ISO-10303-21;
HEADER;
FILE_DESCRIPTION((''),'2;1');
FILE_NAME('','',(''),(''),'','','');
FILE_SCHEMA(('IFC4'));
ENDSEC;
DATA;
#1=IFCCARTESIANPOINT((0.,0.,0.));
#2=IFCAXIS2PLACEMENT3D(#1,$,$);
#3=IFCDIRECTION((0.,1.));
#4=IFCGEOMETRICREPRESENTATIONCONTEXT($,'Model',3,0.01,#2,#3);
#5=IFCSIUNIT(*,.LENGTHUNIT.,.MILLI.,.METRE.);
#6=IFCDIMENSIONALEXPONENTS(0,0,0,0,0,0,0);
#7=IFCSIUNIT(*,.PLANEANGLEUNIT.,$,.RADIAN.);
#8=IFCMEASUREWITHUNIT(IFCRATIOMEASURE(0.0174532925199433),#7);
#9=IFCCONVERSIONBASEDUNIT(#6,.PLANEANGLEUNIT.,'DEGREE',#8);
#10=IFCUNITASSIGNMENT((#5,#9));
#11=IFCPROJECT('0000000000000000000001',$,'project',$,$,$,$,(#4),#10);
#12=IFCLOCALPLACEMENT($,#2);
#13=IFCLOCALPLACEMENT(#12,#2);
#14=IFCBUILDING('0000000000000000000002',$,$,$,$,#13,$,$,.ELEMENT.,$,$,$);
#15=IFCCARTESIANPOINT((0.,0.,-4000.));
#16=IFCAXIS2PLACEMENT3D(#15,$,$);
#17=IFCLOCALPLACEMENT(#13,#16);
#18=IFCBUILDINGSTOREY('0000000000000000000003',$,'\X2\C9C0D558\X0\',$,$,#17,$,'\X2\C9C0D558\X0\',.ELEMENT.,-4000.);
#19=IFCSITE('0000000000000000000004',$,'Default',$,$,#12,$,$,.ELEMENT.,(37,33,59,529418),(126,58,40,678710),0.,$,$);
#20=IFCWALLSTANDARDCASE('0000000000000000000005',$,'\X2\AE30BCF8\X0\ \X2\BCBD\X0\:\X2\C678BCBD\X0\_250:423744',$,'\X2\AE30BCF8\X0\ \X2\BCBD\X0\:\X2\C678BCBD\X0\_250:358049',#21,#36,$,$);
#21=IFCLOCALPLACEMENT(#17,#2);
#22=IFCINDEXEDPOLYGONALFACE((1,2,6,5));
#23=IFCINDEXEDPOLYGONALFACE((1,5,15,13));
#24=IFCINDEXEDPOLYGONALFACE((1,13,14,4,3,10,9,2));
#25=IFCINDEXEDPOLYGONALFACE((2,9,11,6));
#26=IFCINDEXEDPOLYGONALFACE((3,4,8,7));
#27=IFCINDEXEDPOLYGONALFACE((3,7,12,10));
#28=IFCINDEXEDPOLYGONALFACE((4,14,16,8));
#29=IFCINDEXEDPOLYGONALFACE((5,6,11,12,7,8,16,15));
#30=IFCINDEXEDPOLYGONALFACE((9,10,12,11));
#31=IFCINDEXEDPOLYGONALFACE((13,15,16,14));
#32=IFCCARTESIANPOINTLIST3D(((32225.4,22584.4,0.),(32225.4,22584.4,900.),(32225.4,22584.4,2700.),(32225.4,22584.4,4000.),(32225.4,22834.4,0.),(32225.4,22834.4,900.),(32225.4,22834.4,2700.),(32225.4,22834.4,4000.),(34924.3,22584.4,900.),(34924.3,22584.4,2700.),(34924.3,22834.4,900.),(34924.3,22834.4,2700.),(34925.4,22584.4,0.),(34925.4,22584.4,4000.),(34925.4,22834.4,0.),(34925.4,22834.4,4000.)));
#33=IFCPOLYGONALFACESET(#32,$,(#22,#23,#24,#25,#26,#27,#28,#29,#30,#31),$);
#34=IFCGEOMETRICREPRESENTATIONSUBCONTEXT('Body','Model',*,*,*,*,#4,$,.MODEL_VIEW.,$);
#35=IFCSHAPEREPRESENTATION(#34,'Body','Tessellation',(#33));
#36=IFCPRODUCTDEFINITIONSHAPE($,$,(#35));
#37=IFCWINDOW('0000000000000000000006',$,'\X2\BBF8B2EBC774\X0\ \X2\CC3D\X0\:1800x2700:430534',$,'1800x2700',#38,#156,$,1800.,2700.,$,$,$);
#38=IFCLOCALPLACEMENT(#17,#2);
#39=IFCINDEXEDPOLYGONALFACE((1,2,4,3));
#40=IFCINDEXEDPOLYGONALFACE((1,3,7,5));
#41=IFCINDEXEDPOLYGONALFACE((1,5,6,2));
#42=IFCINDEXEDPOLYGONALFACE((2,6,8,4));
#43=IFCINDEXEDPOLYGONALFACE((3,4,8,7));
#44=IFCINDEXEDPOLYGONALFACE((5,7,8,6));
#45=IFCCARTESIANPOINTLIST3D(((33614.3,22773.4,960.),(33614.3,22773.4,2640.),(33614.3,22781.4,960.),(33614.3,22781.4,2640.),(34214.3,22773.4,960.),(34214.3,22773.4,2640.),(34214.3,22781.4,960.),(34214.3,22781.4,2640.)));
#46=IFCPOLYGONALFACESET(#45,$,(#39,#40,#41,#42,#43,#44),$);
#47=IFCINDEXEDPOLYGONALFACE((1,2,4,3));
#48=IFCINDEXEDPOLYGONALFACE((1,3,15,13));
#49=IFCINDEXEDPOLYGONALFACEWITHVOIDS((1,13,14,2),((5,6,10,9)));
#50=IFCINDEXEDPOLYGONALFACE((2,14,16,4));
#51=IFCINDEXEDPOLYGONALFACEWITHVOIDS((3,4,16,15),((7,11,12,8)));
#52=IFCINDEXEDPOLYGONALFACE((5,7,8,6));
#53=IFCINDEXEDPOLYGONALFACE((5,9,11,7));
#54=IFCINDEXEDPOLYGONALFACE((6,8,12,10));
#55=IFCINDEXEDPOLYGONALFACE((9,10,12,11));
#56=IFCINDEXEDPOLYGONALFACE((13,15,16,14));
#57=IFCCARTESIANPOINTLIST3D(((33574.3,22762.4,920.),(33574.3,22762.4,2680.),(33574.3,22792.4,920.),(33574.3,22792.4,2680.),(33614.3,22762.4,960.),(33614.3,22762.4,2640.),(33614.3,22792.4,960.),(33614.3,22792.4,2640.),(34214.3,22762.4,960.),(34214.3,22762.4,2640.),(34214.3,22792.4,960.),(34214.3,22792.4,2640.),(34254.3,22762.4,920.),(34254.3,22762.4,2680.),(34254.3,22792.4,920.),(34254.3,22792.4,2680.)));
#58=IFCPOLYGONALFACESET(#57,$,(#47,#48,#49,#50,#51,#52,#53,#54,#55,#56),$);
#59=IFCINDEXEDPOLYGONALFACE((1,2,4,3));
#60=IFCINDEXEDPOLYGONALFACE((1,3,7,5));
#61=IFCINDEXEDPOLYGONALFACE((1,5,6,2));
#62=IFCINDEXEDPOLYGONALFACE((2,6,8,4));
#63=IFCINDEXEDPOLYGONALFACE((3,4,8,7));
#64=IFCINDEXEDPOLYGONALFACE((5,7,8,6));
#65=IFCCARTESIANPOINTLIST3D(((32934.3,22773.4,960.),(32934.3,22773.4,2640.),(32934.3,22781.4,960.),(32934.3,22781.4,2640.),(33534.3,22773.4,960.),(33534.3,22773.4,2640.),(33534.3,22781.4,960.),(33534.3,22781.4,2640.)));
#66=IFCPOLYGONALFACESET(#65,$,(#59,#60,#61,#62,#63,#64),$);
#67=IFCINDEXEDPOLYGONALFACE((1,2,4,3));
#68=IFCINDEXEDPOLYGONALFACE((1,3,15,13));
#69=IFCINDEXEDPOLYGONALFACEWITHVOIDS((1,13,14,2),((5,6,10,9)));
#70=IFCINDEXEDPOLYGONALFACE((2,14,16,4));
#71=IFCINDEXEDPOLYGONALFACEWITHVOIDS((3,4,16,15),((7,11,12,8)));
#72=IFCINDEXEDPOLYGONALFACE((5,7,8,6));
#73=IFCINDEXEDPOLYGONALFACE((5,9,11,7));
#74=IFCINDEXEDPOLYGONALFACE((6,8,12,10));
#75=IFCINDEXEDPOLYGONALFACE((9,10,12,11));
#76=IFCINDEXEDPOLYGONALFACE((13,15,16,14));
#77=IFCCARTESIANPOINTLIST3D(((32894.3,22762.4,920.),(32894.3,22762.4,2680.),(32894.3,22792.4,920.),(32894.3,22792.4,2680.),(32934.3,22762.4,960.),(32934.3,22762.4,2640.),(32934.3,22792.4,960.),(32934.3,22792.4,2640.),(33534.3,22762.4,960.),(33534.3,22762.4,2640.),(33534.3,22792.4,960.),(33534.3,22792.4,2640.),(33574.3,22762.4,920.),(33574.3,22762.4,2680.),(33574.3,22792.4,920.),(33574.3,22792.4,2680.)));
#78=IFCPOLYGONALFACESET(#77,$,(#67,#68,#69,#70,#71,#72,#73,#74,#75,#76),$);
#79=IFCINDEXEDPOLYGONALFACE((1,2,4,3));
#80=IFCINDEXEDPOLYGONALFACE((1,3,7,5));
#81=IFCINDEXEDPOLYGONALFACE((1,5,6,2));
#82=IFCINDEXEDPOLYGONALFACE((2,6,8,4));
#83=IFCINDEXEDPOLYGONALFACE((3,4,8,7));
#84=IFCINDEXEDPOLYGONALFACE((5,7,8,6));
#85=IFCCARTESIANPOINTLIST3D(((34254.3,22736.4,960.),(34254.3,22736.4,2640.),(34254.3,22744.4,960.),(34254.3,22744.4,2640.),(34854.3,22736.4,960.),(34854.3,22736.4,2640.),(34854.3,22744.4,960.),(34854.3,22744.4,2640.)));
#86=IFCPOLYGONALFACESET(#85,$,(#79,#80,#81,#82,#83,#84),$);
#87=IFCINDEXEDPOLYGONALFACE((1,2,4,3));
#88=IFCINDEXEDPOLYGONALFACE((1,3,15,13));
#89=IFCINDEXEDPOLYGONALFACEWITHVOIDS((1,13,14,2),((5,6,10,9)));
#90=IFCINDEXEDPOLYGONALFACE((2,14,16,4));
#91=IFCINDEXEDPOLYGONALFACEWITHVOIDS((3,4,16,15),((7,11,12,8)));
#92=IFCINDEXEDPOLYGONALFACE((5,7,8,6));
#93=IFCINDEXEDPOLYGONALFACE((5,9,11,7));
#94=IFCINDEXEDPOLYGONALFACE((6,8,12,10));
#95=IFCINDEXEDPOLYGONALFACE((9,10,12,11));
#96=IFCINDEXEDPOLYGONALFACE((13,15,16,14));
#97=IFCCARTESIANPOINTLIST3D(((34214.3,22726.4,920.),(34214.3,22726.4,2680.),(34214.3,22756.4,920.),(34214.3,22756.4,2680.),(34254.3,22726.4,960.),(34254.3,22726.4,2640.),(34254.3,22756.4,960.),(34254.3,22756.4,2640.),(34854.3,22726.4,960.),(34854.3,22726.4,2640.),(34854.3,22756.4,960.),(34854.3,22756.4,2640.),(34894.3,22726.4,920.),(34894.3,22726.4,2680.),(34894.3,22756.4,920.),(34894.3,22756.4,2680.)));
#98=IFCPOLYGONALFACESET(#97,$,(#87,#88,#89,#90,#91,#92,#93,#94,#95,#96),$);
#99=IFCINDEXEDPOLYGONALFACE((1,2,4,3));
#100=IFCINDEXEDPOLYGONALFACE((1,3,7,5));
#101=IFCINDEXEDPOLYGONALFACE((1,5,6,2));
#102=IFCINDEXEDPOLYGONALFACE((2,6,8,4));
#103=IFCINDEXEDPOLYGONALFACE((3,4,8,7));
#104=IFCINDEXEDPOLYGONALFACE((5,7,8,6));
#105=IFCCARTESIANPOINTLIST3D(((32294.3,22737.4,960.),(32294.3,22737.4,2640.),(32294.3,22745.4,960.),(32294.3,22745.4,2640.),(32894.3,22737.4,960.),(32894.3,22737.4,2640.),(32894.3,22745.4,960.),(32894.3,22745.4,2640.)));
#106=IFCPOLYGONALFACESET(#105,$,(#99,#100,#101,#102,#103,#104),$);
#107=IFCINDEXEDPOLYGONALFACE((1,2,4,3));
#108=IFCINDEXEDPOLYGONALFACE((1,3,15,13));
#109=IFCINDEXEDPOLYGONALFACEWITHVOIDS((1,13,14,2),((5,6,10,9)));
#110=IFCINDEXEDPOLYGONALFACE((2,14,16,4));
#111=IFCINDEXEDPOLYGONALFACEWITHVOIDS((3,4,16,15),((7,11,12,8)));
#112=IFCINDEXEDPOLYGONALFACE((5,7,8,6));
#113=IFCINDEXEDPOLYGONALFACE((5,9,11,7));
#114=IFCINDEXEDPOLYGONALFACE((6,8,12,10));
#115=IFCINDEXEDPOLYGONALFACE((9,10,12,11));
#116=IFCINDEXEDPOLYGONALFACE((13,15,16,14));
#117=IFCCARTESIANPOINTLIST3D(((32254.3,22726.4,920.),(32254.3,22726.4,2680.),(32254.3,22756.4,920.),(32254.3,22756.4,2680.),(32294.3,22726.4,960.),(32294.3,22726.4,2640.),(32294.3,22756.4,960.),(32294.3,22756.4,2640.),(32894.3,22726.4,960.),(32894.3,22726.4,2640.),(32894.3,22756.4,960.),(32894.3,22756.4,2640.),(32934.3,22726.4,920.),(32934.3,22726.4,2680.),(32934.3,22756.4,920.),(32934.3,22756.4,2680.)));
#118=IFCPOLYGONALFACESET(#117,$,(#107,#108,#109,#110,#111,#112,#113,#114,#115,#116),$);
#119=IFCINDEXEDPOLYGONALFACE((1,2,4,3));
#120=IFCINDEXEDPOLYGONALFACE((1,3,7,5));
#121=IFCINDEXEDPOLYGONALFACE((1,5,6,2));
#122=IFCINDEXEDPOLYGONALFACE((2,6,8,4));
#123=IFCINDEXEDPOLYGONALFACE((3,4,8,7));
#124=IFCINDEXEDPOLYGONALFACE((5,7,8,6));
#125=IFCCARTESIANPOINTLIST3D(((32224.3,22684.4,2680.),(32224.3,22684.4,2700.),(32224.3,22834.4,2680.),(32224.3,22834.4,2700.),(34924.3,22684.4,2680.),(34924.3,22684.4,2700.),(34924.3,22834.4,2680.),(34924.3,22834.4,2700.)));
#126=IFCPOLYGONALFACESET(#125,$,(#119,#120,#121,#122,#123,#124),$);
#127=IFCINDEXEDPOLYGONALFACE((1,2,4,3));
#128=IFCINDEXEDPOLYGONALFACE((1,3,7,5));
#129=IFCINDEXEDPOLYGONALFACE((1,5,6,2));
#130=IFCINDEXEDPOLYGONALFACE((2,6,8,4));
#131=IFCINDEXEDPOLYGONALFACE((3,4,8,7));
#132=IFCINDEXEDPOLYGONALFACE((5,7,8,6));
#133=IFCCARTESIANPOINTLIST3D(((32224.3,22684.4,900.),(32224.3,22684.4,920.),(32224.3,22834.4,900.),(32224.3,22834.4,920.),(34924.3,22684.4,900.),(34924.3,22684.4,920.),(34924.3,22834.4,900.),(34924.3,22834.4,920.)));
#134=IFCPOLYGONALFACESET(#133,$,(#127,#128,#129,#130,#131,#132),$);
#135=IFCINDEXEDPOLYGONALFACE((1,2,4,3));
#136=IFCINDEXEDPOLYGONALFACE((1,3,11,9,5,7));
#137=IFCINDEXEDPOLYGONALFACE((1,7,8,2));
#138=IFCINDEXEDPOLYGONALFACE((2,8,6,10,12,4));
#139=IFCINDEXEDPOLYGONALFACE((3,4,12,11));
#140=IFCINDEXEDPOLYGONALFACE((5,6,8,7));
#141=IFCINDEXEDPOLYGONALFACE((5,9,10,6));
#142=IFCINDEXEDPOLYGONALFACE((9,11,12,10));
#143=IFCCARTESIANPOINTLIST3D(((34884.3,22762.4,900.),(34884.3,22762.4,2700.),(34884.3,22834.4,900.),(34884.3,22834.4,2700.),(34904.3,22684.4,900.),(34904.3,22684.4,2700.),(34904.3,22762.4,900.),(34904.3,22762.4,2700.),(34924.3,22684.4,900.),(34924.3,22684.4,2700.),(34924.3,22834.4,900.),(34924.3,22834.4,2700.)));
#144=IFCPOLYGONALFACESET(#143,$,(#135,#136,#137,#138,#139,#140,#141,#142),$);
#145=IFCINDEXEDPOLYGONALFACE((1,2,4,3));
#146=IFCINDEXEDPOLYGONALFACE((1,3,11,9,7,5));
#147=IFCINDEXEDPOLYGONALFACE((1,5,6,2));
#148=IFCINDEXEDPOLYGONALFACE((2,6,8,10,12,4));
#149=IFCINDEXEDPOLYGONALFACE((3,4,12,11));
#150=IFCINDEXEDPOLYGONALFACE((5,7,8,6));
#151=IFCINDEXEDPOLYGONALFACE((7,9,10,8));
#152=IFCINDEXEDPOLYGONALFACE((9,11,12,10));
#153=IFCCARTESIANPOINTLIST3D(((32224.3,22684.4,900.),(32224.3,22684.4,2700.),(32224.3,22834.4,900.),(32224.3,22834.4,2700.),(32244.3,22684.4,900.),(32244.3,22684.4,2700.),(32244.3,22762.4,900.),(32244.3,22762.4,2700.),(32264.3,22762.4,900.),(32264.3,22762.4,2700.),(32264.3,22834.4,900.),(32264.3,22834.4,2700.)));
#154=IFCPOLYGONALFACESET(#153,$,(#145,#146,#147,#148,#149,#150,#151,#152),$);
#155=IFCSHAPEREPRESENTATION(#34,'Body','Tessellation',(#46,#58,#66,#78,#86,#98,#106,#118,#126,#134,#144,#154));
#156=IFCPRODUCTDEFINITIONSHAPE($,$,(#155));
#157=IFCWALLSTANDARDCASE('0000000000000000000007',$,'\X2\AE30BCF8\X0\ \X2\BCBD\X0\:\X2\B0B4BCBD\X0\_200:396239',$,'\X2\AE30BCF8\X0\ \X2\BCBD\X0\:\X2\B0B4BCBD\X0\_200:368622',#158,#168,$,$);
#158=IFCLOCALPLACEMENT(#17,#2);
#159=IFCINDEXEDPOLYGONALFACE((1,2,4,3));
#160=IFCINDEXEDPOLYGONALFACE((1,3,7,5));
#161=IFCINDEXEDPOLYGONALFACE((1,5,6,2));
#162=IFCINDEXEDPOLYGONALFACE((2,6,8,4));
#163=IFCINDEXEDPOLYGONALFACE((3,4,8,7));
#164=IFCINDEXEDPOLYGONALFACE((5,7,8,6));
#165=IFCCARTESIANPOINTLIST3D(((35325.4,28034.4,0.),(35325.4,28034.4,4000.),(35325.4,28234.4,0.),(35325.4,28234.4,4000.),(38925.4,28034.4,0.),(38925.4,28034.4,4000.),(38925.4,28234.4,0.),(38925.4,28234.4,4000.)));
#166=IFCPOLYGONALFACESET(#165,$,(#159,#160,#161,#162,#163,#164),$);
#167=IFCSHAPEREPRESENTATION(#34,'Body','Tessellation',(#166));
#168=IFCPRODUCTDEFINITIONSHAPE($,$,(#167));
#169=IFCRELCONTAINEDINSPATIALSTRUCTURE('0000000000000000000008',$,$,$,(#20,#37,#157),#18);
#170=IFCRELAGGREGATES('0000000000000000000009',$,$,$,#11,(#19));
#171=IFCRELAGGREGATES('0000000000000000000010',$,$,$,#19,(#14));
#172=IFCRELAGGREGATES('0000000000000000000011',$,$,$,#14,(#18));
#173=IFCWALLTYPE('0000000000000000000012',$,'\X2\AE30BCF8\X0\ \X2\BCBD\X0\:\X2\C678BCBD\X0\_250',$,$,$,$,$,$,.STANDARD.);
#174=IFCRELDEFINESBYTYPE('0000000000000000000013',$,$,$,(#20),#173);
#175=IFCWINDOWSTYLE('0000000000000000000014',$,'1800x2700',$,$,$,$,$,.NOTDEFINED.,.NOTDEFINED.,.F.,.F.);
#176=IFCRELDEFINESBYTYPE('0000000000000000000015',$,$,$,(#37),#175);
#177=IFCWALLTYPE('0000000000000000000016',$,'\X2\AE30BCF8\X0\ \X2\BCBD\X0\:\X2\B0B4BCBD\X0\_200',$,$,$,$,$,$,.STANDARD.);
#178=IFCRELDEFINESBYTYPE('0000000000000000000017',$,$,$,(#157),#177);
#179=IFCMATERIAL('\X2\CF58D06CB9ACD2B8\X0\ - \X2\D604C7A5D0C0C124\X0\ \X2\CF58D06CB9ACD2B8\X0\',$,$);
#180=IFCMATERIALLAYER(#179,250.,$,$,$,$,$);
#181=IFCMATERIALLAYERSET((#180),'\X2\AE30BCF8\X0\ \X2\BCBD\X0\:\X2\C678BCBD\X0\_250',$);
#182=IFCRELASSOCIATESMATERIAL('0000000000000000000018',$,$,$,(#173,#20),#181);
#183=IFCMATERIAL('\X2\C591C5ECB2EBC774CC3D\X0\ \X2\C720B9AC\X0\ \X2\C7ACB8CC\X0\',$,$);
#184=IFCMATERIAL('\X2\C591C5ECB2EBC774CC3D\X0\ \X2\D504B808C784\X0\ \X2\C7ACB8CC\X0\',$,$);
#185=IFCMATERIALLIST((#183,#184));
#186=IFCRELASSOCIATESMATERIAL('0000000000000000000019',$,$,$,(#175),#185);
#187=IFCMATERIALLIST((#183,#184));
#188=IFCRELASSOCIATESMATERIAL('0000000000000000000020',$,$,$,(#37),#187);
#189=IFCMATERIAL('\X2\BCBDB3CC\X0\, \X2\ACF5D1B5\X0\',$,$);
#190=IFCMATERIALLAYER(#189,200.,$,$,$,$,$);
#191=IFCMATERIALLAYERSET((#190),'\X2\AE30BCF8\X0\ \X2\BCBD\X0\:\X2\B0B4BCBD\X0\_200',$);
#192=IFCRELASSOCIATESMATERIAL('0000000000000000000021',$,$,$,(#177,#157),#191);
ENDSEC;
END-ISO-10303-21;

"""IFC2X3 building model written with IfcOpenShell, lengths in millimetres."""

from ifc_helpers import new_model, entity, si_unit, converted_unit, direction, frame, frame_2d, origin, origin_2d_with_axis, place, context, subcontext, project, spatial, polyline, rectangle, outline, extrude, source, transform, mapped, material, material_list, layer, layer_set, layer_usage, type_object, type_shapes, element, fill, save


model = new_model("IFC2X3")

# Units and contexts
model_context = context("Model", 3, precision=0.01, world=origin(), true_north=direction((0.0, 1.0)))
body_context = subcontext(model_context, "Body", "Model", "MODEL_VIEW")
ifc_project = project(units=[si_unit("LENGTHUNIT", "METRE", prefix="MILLI"), converted_unit("PLANEANGLEUNIT", "DEGREE", entity("IfcRatioMeasure", 0.0174532925199433), si_unit("PLANEANGLEUNIT", "RADIAN"), dimensions=[0, 0, 0, 0, 0, 0, 0])], contexts=[model_context])

# Site, building, storey
site_placement = place(None, origin())
site = spatial("IfcSite", under=ifc_project, at=site_placement, Name="Default", CompositionType="ELEMENT", RefLatitude=(37, 33, 59, 529418), RefLongitude=(126, 58, 40, 678710), RefElevation=0.0)
building_placement = place(site_placement, origin())
building = spatial("IfcBuilding", under=site, at=building_placement, CompositionType="ELEMENT")
storey_placement = place(building_placement, frame((0.0, 0.0, -4000.0)))
storey = spatial("IfcBuildingStorey", under=building, at=storey_placement, Name="지하", LongName="지하", CompositionType="ELEMENT", Elevation=-4000.0)

# Shared definitions
ifc_material_1 = material(Name="콘크리트 - 현장타설 콘크리트")

# Wall, opening, window
ifc_material_2 = material(Name="양여닫이창 유리 재료")
ifc_material_3 = material(Name="양여닫이창 프레임 재료")
ifc_layer_1 = layer(ifc_material_1, 250.0)
ifc_layer_set_1 = layer_set([ifc_layer_1], Name="기본 벽:외벽_250")
ifc_layer_usage_1 = layer_usage(ifc_layer_set_1, "AXIS2", "NEGATIVE", 125.0)
wall_type_1 = type_object("IfcWallType", Name="기본 벽:외벽_250", PredefinedType="STANDARD", material=ifc_layer_set_1)
wall_1_placement = place(storey_placement, frame((32225.4, 22709.4, 0.0)))
wall_1 = element("IfcWallStandardCase", 1, at=wall_1_placement, inside=storey, type_object=wall_type_1, material=ifc_layer_usage_1, Name="기본 벽:외벽_250:423744", ObjectType="기본 벽:외벽_250:358049", context=body_context, shape_type="SweptSolid", body=[
    extrude(rectangle(XDim=2700.0, YDim=250.0, at=frame_2d((1350.0, 0.0), x_axis=(-1.0, 0.0))), origin(), (0.0, 0.0, 1.0), 4000.0),
])
opening_1_placement = place(wall_1_placement, frame((-1.1, -125.0, 900.0)))
opening_1 = element("IfcOpeningElement", 2, at=opening_1_placement, cuts=wall_1, ObjectType="Opening", context=body_context, shape_type="SweptSolid", body=[
    extrude(rectangle(XDim=1800.0, YDim=2700.0, at=frame_2d((900.0, 1350.0), x_axis=(1.0, 0.0))), frame((0.0, 0.0, 0.0), z_axis=(0.0, 1.0, 0.0), x_axis=(0.0, 0.0, 1.0)), (0.0, 0.0, 1.0), 250.0),
])
ifc_material_list_1 = material_list([ifc_material_2, ifc_material_3])
ifc_material_list_2 = material_list([ifc_material_2, ifc_material_3])
window_style_1 = type_object("IfcWindowStyle", Name="1800x2700", ConstructionType="NOTDEFINED", OperationType="NOTDEFINED", ParameterTakesPrecedence=False, Sizeable=False, material=ifc_material_list_2)
shared_shape_1 = source(origin(), body_context, "Body", "SweptSolid", [
    extrude(rectangle(XDim=8.0, YDim=600.0, at=frame_2d((0.0, 0.0), x_axis=(1.0, 0.0))), frame((1690.0, 193.0, 60.0), z_axis=(0.0, 0.0, 1.0), x_axis=(0.0, 1.0, 0.0)), (0.0, 0.0, 1.0), 1680.0),
    extrude(outline(polyline([(-880.0, -340.0), (880.0, -340.0), (880.0, 340.0), (-880.0, 340.0), (-880.0, -340.0)]), holes=[polyline([(840.0, -300.0), (-840.0, -300.0), (-840.0, 300.0), (840.0, 300.0), (840.0, -300.0)])]), frame((1690.0, 178.0, 900.0), z_axis=(0.0, 1.0, 0.0), x_axis=(0.0, 0.0, -1.0)), (0.0, 0.0, 1.0), 30.0),
    extrude(rectangle(XDim=8.0, YDim=600.0, at=origin_2d_with_axis()), frame((1010.0, 193.0, 60.0), z_axis=(0.0, 0.0, 1.0), x_axis=(0.0, 1.0, 0.0)), (0.0, 0.0, 1.0), 1680.0),
    extrude(outline(polyline([(-880.0, -340.0), (880.0, -340.0), (880.0, 340.0), (-880.0, 340.0), (-880.0, -340.0)]), holes=[polyline([(840.0, -300.0), (-840.0, -300.0), (-840.0, 300.0), (840.0, 300.0), (840.0, -300.0)])]), frame((1010.0, 178.0, 900.0), z_axis=(0.0, 1.0, 0.0), x_axis=(0.0, 0.0, -1.0)), (0.0, 0.0, 1.0), 30.0),
    extrude(rectangle(XDim=8.0, YDim=600.0, at=frame_2d((0.0, 0.0), x_axis=(1.0, 0.0))), frame((2330.0, 156.0, 60.0), z_axis=(0.0, 0.0, 1.0), x_axis=(0.0, 1.0, 0.0)), (0.0, 0.0, 1.0), 1680.0),
    extrude(outline(polyline([(-880.0, -340.0), (880.0, -340.0), (880.0, 340.0), (-880.0, 340.0), (-880.0, -340.0)]), holes=[polyline([(840.0, -300.0), (-840.0, -300.0), (-840.0, 300.0), (840.0, 300.0), (840.0, -300.0)])]), frame((2330.0, 142.0, 900.0), z_axis=(0.0, 1.0, 0.0), x_axis=(0.0, 0.0, -1.0)), (0.0, 0.0, 1.0), 30.0),
    extrude(rectangle(XDim=8.0, YDim=600.0, at=frame_2d((0.0, 0.0), x_axis=(1.0, 0.0))), frame((370.0, 157.0, 60.0), z_axis=(0.0, 0.0, 1.0), x_axis=(0.0, 1.0, 0.0)), (0.0, 0.0, 1.0), 1680.0),
    extrude(outline(polyline([(-880.0, -340.0), (880.0, -340.0), (880.0, 340.0), (-880.0, 340.0), (-880.0, -340.0)]), holes=[polyline([(840.0, -300.0), (-840.0, -300.0), (-840.0, 300.0), (840.0, 300.0), (840.0, -300.0)])]), frame((370.0, 142.0, 900.0), z_axis=(0.0, 1.0, 0.0), x_axis=(0.0, 0.0, -1.0)), (0.0, 0.0, 1.0), 30.0),
    extrude(rectangle(XDim=2700.0, YDim=150.0, at=origin_2d_with_axis()), frame((1350.0, 175.0, 1780.0), z_axis=(0.0, 0.0, 1.0), x_axis=(-1.0, 0.0, 0.0)), (0.0, 0.0, 1.0), 20.0),
    extrude(rectangle(XDim=2700.0, YDim=150.0, at=origin_2d_with_axis()), frame((1350.0, 175.0, 0.0), z_axis=(0.0, 0.0, 1.0), x_axis=(-1.0, 0.0, 0.0)), (0.0, 0.0, 1.0), 20.0),
    extrude(outline(polyline([(-74.0, -20.0), (-2.0, -20.0), (-2.0, 0.0), (76.0, 0.0), (76.0, 20.0), (-74.0, 20.0), (-74.0, -20.0)])), frame((2680.0, 176.0, 0.0), z_axis=(0.0, 0.0, 1.0), x_axis=(0.0, -1.0, 0.0)), (0.0, 0.0, 1.0), 1800.0),
    extrude(outline(polyline([(-20.0, -74.0), (20.0, -74.0), (20.0, 76.0), (0.0, 76.0), (0.0, -2.0), (-20.0, -2.0), (-20.0, -74.0)])), frame((20.0, 176.0, 0.0), z_axis=(0.0, 0.0, 1.0), x_axis=(-1.0, 0.0, 0.0)), (0.0, 0.0, 1.0), 1800.0),
])
type_shapes(window_style_1, [shared_shape_1])
window_1_placement = place(opening_1_placement, origin())
window_1 = element("IfcWindow", 3, at=window_1_placement, inside=storey, type_object=window_style_1, material=ifc_material_list_1, Name="미닫이 창:1800x2700:430534", ObjectType="1800x2700", OverallHeight=1800.0, OverallWidth=2700.0, context=body_context, shape_type="MappedRepresentation", body=[
    mapped(shared_shape_1, transform((0.0, 0.0, 0.0), scale=1.0)),
])
fill(opening_1, window_1)

# Wall
ifc_material_4 = material(Name="벽돌, 공통")
ifc_layer_2 = layer(ifc_material_4, 200.0)
ifc_layer_set_2 = layer_set([ifc_layer_2], Name="기본 벽:내벽_200")
ifc_layer_usage_2 = layer_usage(ifc_layer_set_2, "AXIS2", "NEGATIVE", 100.0)
wall_type_2 = type_object("IfcWallType", Name="기본 벽:내벽_200", PredefinedType="STANDARD", material=ifc_layer_set_2)
wall_2_placement = place(storey_placement, frame((35325.4, 28134.4, 0.0)))
element("IfcWallStandardCase", 4, at=wall_2_placement, inside=storey, type_object=wall_type_2, material=ifc_layer_usage_2, Name="기본 벽:내벽_200:396239", ObjectType="기본 벽:내벽_200:368622", context=body_context, shape_type="SweptSolid", body=[
    extrude(rectangle(XDim=3600.0, YDim=200.0, at=frame_2d((1800.0, 0.0), x_axis=(-1.0, 0.0))), origin(), (0.0, 0.0, 1.0), 4000.0),
])

save(model, "model.ifc")
